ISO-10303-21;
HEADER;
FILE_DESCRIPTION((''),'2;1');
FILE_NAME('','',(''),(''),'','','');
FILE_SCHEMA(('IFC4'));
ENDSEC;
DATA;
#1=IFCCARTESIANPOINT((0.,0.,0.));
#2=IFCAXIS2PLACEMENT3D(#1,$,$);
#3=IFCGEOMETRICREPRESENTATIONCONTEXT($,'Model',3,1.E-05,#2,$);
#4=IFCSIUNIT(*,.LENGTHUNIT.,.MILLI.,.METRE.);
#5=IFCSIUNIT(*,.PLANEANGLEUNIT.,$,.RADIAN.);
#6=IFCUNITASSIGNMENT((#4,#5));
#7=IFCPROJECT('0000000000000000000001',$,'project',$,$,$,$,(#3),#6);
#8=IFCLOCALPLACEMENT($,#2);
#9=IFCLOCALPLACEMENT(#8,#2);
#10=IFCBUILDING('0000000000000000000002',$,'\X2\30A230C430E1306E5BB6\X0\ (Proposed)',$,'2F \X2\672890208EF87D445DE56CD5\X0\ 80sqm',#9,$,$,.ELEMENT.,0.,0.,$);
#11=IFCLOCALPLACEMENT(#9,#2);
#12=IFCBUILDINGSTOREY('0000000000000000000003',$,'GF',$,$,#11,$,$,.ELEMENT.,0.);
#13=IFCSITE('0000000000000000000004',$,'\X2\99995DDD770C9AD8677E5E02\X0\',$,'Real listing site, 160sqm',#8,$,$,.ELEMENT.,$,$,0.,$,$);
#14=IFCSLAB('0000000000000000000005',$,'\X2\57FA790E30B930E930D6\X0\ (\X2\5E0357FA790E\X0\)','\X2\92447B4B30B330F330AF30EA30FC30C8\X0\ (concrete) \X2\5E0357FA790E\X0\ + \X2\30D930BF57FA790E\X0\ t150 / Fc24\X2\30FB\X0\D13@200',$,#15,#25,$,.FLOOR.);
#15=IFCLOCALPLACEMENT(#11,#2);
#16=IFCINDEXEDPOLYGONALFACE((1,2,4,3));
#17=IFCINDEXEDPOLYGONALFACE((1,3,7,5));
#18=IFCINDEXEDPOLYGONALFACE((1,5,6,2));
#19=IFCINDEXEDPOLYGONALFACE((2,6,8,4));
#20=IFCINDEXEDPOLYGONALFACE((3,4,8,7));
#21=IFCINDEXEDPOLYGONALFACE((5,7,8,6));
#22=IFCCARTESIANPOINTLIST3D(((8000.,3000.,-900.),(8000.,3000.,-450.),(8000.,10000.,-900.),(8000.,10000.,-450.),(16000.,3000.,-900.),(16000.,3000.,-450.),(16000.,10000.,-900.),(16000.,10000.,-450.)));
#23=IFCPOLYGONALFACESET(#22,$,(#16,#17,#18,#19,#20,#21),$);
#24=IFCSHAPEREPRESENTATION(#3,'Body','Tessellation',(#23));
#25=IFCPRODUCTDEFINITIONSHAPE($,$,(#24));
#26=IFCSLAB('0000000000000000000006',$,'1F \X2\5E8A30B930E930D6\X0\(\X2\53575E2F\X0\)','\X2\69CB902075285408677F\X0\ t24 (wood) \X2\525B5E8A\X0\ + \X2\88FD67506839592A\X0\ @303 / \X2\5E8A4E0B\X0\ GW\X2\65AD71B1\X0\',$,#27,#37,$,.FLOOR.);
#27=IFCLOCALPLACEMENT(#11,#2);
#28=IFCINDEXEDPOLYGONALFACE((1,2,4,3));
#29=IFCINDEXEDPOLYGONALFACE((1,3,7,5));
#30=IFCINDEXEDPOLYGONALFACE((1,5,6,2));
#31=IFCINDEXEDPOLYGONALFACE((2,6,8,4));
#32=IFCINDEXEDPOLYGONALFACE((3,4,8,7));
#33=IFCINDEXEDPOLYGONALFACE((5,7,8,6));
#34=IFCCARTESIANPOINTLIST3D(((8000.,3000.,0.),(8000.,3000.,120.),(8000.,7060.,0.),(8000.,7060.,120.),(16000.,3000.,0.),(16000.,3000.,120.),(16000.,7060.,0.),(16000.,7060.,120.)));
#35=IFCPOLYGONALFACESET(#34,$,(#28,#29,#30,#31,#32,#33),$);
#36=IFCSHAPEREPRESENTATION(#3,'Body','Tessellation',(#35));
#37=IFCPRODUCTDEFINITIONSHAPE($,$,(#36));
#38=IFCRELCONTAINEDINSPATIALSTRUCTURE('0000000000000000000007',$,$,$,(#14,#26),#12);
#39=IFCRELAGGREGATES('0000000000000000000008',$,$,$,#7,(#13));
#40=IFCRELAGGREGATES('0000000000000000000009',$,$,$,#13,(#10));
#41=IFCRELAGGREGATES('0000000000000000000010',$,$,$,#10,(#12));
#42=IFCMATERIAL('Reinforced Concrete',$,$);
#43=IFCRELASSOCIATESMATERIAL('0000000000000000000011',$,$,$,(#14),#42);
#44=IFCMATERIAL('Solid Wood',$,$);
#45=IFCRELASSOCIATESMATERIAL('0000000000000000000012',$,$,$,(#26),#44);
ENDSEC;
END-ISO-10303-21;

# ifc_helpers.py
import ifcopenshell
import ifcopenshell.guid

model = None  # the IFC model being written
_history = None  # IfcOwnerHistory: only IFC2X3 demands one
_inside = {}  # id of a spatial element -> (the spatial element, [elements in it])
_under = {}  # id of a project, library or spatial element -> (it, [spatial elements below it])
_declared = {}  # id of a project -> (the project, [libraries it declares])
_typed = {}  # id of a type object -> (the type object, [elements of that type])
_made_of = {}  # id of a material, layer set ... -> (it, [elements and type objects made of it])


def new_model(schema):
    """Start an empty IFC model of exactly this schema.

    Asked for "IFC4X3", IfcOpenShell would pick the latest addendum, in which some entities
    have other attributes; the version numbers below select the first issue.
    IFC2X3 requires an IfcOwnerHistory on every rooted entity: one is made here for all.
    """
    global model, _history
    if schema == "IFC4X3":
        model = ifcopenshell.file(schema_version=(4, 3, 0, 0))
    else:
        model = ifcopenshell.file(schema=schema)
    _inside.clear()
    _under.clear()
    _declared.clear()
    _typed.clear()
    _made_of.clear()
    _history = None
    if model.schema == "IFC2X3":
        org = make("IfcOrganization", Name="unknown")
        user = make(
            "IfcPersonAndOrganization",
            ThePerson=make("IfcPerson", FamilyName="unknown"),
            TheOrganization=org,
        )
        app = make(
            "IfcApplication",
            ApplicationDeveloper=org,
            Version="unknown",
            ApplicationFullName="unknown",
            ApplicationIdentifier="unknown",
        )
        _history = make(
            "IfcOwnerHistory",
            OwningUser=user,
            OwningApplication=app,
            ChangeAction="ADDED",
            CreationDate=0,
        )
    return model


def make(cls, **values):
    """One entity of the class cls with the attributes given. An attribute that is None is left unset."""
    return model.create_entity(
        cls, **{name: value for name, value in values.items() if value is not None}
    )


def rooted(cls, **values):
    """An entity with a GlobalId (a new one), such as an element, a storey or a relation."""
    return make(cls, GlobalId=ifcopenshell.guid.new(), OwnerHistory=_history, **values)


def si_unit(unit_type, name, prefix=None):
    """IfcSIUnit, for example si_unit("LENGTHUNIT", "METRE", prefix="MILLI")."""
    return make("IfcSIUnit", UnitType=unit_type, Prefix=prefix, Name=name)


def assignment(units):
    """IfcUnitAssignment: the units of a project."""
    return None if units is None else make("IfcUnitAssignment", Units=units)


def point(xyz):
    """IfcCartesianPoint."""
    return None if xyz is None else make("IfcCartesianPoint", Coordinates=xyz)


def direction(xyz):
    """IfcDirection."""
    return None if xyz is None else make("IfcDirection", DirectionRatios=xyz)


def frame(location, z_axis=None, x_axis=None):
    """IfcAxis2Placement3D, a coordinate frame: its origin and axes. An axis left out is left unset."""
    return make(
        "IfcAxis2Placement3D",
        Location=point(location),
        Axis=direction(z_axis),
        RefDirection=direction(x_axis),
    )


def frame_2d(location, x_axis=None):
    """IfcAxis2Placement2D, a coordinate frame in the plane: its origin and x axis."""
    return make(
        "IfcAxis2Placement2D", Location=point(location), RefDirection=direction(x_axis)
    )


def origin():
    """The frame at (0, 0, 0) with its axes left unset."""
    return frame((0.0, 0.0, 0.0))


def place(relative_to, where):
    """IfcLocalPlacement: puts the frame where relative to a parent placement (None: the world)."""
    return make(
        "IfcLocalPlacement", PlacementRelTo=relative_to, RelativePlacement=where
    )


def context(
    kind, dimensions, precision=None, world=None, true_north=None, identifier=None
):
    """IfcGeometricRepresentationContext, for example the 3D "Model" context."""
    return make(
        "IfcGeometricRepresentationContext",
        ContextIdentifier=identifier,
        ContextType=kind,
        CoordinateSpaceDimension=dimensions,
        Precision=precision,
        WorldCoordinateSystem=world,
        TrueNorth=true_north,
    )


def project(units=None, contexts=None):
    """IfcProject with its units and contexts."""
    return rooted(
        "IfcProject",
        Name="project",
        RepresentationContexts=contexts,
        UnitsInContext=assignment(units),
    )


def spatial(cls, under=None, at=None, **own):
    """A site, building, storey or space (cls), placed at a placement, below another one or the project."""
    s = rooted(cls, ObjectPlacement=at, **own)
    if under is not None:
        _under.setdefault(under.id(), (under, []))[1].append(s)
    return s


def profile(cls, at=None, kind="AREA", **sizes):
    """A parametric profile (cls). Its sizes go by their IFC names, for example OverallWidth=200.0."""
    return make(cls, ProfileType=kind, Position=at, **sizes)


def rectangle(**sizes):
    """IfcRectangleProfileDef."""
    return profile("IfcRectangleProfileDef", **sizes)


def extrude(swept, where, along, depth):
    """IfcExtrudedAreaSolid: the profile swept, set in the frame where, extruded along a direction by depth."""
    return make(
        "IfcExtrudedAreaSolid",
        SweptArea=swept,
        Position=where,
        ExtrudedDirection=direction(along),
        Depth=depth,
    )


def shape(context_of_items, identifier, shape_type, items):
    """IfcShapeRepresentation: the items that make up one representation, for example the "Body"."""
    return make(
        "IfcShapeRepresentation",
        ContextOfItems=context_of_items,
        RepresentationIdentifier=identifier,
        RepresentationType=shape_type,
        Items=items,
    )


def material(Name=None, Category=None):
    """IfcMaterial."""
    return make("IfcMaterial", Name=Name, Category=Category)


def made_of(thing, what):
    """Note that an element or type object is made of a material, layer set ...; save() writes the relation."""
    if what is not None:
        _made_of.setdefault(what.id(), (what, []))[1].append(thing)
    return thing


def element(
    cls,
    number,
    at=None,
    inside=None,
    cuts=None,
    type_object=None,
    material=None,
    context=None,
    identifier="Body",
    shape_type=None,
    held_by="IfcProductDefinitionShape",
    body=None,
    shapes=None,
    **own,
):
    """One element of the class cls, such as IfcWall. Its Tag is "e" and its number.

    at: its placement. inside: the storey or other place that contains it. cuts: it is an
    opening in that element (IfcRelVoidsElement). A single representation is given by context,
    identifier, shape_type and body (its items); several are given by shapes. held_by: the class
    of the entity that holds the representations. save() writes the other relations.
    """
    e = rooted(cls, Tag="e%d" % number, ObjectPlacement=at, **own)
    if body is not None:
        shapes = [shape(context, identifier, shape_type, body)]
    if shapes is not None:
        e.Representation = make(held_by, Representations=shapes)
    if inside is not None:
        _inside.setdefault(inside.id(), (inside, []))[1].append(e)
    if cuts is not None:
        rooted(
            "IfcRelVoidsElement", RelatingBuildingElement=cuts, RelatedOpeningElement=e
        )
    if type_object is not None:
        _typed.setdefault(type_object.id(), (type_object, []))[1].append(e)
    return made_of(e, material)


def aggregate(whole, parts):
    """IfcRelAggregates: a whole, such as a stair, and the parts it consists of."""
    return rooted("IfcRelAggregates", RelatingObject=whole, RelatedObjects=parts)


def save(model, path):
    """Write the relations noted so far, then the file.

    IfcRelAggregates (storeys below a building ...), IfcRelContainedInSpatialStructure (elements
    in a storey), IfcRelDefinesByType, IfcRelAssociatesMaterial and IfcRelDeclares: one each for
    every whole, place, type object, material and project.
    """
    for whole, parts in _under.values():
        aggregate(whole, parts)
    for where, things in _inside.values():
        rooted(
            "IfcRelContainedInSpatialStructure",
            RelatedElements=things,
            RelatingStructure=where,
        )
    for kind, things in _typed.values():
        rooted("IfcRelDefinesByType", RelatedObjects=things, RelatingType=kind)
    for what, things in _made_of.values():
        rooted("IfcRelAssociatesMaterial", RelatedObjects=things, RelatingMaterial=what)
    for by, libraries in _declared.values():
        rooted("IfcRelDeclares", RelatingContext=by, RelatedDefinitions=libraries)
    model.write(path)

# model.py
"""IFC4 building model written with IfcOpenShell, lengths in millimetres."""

from ifc_helpers import new_model, si_unit, frame, frame_2d, origin, place, context, project, spatial, rectangle, extrude, material, element, save


model = new_model("IFC4")

# Units and contexts
model_context = context("Model", 3, precision=1e-05, world=origin())
ifc_project = project(units=[si_unit("LENGTHUNIT", "METRE", prefix="MILLI"), si_unit("PLANEANGLEUNIT", "RADIAN")], contexts=[model_context])

# Site, building, storey
site_placement = place(None, origin())
site = spatial("IfcSite", under=ifc_project, at=site_placement, Name="香川県高松市", ObjectType="Real listing site, 160sqm", CompositionType="ELEMENT", RefElevation=0.0)
building_placement = place(site_placement, origin())
building = spatial("IfcBuilding", under=site, at=building_placement, Name="アツメの家 (Proposed)", ObjectType="2F 木造軸組工法 80sqm", CompositionType="ELEMENT", ElevationOfRefHeight=0.0, ElevationOfTerrain=0.0)
storey_placement = place(building_placement, origin())
storey = spatial("IfcBuildingStorey", under=building, at=storey_placement, Name="GF", CompositionType="ELEMENT", Elevation=0.0)

# Slabs
ifc_material_1 = material(Name="Reinforced Concrete")
slab_1_placement = place(storey_placement, frame((4000.0, 1500.0, -450.0)))
element("IfcSlab", 1, at=slab_1_placement, inside=storey, material=ifc_material_1, Name="基礎スラブ (布基礎)", Description="鉄筋コンクリート (concrete) 布基礎 + ベタ基礎 t150 / Fc24・D13@200", PredefinedType="FLOOR", context=model_context, shape_type="SweptSolid", body=[
    extrude(rectangle(XDim=8000.0, YDim=7000.0, at=frame_2d((4000.0, 3500.0))), frame((4000.0, 1500.0, -450.0)), (0.0, 0.0, 1.0), 450.0),
])
ifc_material_2 = material(Name="Solid Wood")
slab_2_placement = place(storey_placement, frame((4000.0, 1500.0, 0.0)))
element("IfcSlab", 2, at=slab_2_placement, inside=storey, material=ifc_material_2, Name="1F 床スラブ(南帯)", Description="構造用合板 t24 (wood) 剛床 + 製材根太 @303 / 床下 GW断熱", PredefinedType="FLOOR", context=model_context, shape_type="SweptSolid", body=[
    extrude(rectangle(XDim=8000.0, YDim=4060.0, at=frame_2d((4000.0, 2030.0))), frame((4000.0, 1500.0, 0.0)), (0.0, 0.0, 1.0), 120.0),
])

save(model, "model.ifc")
